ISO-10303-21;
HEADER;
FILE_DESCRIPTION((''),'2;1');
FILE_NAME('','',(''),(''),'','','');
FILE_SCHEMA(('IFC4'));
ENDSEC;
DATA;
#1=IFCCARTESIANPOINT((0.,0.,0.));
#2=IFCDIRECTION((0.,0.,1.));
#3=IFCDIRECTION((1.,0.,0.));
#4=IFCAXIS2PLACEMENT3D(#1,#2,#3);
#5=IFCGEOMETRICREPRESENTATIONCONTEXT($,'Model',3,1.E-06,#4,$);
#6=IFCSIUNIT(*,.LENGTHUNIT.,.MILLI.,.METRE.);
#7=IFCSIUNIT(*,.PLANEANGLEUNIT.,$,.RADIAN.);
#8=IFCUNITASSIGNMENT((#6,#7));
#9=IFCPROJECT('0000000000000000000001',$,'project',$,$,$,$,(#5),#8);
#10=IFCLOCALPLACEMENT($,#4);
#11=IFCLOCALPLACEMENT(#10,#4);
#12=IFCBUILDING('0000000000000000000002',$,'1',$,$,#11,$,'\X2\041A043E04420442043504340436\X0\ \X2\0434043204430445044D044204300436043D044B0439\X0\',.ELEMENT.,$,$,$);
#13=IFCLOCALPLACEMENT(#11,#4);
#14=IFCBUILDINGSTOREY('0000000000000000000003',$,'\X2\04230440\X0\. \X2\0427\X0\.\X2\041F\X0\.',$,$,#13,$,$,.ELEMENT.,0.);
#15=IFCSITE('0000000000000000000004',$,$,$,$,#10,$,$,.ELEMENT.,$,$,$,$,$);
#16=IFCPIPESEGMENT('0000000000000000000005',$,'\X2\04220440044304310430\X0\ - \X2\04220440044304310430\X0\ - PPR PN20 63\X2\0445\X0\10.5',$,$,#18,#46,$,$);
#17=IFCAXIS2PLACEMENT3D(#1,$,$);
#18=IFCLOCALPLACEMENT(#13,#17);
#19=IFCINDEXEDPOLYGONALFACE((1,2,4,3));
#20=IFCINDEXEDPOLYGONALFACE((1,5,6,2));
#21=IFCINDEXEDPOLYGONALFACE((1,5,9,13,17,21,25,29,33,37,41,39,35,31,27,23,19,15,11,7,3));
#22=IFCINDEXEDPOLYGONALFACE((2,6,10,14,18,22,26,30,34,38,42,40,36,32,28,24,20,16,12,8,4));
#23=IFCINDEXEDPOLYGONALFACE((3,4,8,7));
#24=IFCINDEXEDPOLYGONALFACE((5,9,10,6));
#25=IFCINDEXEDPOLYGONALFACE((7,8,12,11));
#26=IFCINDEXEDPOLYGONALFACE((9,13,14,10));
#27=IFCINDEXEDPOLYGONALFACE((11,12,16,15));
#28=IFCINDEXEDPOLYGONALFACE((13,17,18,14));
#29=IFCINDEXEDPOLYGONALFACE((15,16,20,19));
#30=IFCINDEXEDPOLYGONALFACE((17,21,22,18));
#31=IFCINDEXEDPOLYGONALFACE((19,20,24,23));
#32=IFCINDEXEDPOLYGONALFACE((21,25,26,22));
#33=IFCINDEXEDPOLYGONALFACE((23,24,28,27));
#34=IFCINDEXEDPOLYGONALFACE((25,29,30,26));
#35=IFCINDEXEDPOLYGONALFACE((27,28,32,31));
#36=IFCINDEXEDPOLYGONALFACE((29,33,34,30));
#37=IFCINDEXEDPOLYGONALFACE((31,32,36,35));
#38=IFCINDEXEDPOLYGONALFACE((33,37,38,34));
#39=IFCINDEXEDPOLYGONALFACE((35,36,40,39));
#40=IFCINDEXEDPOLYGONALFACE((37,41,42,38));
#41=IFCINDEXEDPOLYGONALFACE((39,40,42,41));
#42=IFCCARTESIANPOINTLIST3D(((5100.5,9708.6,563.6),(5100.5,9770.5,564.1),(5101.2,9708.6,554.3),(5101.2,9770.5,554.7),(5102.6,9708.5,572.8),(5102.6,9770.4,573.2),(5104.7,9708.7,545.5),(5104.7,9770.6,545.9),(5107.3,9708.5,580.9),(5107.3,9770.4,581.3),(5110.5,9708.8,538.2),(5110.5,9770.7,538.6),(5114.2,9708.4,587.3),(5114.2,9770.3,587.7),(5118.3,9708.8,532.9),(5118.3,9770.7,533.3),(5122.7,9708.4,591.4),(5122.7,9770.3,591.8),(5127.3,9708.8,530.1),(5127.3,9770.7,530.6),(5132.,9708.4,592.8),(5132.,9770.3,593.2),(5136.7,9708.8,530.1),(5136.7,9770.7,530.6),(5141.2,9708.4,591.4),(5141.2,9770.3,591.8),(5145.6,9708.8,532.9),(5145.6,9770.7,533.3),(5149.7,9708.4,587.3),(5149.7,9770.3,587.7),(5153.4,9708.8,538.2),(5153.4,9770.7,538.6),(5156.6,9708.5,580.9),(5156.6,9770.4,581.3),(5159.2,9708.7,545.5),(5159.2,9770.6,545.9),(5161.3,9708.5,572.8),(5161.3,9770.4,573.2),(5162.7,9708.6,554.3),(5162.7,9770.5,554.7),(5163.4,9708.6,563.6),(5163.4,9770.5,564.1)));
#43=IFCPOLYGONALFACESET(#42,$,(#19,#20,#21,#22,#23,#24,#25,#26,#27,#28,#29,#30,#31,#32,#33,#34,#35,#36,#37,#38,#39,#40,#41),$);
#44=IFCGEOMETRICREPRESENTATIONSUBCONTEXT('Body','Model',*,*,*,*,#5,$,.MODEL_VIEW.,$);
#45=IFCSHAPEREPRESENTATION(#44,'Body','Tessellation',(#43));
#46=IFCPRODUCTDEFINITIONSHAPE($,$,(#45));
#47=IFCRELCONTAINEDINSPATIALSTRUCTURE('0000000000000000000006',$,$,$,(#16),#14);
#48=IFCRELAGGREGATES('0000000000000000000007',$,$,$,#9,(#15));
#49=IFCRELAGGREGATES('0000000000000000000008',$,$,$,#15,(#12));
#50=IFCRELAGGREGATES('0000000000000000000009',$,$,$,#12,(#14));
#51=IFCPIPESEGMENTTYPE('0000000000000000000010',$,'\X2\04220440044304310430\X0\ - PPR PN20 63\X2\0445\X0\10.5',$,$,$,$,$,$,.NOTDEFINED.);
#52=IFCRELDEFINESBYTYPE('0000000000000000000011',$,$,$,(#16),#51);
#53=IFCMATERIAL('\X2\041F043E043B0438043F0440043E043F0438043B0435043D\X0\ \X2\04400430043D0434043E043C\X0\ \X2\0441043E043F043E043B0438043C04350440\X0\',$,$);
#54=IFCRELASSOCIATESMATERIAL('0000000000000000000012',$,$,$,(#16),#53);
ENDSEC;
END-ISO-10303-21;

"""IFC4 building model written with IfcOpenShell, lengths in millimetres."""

from ifc_helpers import new_model, entity, si_unit, frame, origin_with_axes, place, context, subcontext, project, spatial, source, transform, mapped, material, type_object, element, save


model = new_model("IFC4")

# Units and contexts
model_context = context("Model", 3, precision=1e-06, world=origin_with_axes())
body_context = subcontext(model_context, "Body", "Model", "MODEL_VIEW")
ifc_project = project(units=[si_unit("LENGTHUNIT", "METRE", prefix="MILLI"), si_unit("PLANEANGLEUNIT", "RADIAN")], contexts=[model_context])

# Site, building, storey
site_placement = place(None, origin_with_axes())
site = spatial("IfcSite", under=ifc_project, at=site_placement, CompositionType="ELEMENT")
building_placement = place(site_placement, origin_with_axes())
building = spatial("IfcBuilding", under=site, at=building_placement, Name="1", LongName="Коттедж двухэтажный", CompositionType="ELEMENT")
storey_placement = place(building_placement, origin_with_axes())
storey = spatial("IfcBuildingStorey", under=building, at=storey_placement, Name="Ур. Ч.П.", CompositionType="ELEMENT", Elevation=0.0)

# Pipe segment
ifc_material = material(Name="Полипропилен рандом сополимер")
pipe_segment_type_1 = type_object("IfcPipeSegmentType", Name="Труба - PPR PN20 63х10.5", PredefinedType="NOTDEFINED")
shared_shape_1 = source(origin_with_axes(), body_context, "Body", "AdvancedSweptSolid", [
    entity("IfcSweptDiskSolid", entity("IfcIndexedPolyCurve", entity("IfcCartesianPointList3D", [[0.0, 0.0, 0.0], [61.9, 0.0, 0.4]]), [entity("IfcLineIndex", [1, 2])]), 31.5),
])
pipe_segment_1_placement = place(storey_placement, frame((5132.0, 9708.6, 561.3), z_axis=(0.0, 0.0, 1.0), x_axis=(0.0, 1.0, 0.0)))
element("IfcPipeSegment", 1, at=pipe_segment_1_placement, inside=storey, type_object=pipe_segment_type_1, material=ifc_material, Name="Труба - Труба - PPR PN20 63х10.5", context=body_context, shape_type="MappedRepresentation", body=[
    mapped(shared_shape_1, transform((0.0, 0.0, 0.0), x_axis=(1.0, 0.0, 0.0), y_axis=(0.0, 1.0, 0.0), z_axis=(0.0, 0.0, 1.0), scale=1.0)),
])

save(model, "model.ifc")
